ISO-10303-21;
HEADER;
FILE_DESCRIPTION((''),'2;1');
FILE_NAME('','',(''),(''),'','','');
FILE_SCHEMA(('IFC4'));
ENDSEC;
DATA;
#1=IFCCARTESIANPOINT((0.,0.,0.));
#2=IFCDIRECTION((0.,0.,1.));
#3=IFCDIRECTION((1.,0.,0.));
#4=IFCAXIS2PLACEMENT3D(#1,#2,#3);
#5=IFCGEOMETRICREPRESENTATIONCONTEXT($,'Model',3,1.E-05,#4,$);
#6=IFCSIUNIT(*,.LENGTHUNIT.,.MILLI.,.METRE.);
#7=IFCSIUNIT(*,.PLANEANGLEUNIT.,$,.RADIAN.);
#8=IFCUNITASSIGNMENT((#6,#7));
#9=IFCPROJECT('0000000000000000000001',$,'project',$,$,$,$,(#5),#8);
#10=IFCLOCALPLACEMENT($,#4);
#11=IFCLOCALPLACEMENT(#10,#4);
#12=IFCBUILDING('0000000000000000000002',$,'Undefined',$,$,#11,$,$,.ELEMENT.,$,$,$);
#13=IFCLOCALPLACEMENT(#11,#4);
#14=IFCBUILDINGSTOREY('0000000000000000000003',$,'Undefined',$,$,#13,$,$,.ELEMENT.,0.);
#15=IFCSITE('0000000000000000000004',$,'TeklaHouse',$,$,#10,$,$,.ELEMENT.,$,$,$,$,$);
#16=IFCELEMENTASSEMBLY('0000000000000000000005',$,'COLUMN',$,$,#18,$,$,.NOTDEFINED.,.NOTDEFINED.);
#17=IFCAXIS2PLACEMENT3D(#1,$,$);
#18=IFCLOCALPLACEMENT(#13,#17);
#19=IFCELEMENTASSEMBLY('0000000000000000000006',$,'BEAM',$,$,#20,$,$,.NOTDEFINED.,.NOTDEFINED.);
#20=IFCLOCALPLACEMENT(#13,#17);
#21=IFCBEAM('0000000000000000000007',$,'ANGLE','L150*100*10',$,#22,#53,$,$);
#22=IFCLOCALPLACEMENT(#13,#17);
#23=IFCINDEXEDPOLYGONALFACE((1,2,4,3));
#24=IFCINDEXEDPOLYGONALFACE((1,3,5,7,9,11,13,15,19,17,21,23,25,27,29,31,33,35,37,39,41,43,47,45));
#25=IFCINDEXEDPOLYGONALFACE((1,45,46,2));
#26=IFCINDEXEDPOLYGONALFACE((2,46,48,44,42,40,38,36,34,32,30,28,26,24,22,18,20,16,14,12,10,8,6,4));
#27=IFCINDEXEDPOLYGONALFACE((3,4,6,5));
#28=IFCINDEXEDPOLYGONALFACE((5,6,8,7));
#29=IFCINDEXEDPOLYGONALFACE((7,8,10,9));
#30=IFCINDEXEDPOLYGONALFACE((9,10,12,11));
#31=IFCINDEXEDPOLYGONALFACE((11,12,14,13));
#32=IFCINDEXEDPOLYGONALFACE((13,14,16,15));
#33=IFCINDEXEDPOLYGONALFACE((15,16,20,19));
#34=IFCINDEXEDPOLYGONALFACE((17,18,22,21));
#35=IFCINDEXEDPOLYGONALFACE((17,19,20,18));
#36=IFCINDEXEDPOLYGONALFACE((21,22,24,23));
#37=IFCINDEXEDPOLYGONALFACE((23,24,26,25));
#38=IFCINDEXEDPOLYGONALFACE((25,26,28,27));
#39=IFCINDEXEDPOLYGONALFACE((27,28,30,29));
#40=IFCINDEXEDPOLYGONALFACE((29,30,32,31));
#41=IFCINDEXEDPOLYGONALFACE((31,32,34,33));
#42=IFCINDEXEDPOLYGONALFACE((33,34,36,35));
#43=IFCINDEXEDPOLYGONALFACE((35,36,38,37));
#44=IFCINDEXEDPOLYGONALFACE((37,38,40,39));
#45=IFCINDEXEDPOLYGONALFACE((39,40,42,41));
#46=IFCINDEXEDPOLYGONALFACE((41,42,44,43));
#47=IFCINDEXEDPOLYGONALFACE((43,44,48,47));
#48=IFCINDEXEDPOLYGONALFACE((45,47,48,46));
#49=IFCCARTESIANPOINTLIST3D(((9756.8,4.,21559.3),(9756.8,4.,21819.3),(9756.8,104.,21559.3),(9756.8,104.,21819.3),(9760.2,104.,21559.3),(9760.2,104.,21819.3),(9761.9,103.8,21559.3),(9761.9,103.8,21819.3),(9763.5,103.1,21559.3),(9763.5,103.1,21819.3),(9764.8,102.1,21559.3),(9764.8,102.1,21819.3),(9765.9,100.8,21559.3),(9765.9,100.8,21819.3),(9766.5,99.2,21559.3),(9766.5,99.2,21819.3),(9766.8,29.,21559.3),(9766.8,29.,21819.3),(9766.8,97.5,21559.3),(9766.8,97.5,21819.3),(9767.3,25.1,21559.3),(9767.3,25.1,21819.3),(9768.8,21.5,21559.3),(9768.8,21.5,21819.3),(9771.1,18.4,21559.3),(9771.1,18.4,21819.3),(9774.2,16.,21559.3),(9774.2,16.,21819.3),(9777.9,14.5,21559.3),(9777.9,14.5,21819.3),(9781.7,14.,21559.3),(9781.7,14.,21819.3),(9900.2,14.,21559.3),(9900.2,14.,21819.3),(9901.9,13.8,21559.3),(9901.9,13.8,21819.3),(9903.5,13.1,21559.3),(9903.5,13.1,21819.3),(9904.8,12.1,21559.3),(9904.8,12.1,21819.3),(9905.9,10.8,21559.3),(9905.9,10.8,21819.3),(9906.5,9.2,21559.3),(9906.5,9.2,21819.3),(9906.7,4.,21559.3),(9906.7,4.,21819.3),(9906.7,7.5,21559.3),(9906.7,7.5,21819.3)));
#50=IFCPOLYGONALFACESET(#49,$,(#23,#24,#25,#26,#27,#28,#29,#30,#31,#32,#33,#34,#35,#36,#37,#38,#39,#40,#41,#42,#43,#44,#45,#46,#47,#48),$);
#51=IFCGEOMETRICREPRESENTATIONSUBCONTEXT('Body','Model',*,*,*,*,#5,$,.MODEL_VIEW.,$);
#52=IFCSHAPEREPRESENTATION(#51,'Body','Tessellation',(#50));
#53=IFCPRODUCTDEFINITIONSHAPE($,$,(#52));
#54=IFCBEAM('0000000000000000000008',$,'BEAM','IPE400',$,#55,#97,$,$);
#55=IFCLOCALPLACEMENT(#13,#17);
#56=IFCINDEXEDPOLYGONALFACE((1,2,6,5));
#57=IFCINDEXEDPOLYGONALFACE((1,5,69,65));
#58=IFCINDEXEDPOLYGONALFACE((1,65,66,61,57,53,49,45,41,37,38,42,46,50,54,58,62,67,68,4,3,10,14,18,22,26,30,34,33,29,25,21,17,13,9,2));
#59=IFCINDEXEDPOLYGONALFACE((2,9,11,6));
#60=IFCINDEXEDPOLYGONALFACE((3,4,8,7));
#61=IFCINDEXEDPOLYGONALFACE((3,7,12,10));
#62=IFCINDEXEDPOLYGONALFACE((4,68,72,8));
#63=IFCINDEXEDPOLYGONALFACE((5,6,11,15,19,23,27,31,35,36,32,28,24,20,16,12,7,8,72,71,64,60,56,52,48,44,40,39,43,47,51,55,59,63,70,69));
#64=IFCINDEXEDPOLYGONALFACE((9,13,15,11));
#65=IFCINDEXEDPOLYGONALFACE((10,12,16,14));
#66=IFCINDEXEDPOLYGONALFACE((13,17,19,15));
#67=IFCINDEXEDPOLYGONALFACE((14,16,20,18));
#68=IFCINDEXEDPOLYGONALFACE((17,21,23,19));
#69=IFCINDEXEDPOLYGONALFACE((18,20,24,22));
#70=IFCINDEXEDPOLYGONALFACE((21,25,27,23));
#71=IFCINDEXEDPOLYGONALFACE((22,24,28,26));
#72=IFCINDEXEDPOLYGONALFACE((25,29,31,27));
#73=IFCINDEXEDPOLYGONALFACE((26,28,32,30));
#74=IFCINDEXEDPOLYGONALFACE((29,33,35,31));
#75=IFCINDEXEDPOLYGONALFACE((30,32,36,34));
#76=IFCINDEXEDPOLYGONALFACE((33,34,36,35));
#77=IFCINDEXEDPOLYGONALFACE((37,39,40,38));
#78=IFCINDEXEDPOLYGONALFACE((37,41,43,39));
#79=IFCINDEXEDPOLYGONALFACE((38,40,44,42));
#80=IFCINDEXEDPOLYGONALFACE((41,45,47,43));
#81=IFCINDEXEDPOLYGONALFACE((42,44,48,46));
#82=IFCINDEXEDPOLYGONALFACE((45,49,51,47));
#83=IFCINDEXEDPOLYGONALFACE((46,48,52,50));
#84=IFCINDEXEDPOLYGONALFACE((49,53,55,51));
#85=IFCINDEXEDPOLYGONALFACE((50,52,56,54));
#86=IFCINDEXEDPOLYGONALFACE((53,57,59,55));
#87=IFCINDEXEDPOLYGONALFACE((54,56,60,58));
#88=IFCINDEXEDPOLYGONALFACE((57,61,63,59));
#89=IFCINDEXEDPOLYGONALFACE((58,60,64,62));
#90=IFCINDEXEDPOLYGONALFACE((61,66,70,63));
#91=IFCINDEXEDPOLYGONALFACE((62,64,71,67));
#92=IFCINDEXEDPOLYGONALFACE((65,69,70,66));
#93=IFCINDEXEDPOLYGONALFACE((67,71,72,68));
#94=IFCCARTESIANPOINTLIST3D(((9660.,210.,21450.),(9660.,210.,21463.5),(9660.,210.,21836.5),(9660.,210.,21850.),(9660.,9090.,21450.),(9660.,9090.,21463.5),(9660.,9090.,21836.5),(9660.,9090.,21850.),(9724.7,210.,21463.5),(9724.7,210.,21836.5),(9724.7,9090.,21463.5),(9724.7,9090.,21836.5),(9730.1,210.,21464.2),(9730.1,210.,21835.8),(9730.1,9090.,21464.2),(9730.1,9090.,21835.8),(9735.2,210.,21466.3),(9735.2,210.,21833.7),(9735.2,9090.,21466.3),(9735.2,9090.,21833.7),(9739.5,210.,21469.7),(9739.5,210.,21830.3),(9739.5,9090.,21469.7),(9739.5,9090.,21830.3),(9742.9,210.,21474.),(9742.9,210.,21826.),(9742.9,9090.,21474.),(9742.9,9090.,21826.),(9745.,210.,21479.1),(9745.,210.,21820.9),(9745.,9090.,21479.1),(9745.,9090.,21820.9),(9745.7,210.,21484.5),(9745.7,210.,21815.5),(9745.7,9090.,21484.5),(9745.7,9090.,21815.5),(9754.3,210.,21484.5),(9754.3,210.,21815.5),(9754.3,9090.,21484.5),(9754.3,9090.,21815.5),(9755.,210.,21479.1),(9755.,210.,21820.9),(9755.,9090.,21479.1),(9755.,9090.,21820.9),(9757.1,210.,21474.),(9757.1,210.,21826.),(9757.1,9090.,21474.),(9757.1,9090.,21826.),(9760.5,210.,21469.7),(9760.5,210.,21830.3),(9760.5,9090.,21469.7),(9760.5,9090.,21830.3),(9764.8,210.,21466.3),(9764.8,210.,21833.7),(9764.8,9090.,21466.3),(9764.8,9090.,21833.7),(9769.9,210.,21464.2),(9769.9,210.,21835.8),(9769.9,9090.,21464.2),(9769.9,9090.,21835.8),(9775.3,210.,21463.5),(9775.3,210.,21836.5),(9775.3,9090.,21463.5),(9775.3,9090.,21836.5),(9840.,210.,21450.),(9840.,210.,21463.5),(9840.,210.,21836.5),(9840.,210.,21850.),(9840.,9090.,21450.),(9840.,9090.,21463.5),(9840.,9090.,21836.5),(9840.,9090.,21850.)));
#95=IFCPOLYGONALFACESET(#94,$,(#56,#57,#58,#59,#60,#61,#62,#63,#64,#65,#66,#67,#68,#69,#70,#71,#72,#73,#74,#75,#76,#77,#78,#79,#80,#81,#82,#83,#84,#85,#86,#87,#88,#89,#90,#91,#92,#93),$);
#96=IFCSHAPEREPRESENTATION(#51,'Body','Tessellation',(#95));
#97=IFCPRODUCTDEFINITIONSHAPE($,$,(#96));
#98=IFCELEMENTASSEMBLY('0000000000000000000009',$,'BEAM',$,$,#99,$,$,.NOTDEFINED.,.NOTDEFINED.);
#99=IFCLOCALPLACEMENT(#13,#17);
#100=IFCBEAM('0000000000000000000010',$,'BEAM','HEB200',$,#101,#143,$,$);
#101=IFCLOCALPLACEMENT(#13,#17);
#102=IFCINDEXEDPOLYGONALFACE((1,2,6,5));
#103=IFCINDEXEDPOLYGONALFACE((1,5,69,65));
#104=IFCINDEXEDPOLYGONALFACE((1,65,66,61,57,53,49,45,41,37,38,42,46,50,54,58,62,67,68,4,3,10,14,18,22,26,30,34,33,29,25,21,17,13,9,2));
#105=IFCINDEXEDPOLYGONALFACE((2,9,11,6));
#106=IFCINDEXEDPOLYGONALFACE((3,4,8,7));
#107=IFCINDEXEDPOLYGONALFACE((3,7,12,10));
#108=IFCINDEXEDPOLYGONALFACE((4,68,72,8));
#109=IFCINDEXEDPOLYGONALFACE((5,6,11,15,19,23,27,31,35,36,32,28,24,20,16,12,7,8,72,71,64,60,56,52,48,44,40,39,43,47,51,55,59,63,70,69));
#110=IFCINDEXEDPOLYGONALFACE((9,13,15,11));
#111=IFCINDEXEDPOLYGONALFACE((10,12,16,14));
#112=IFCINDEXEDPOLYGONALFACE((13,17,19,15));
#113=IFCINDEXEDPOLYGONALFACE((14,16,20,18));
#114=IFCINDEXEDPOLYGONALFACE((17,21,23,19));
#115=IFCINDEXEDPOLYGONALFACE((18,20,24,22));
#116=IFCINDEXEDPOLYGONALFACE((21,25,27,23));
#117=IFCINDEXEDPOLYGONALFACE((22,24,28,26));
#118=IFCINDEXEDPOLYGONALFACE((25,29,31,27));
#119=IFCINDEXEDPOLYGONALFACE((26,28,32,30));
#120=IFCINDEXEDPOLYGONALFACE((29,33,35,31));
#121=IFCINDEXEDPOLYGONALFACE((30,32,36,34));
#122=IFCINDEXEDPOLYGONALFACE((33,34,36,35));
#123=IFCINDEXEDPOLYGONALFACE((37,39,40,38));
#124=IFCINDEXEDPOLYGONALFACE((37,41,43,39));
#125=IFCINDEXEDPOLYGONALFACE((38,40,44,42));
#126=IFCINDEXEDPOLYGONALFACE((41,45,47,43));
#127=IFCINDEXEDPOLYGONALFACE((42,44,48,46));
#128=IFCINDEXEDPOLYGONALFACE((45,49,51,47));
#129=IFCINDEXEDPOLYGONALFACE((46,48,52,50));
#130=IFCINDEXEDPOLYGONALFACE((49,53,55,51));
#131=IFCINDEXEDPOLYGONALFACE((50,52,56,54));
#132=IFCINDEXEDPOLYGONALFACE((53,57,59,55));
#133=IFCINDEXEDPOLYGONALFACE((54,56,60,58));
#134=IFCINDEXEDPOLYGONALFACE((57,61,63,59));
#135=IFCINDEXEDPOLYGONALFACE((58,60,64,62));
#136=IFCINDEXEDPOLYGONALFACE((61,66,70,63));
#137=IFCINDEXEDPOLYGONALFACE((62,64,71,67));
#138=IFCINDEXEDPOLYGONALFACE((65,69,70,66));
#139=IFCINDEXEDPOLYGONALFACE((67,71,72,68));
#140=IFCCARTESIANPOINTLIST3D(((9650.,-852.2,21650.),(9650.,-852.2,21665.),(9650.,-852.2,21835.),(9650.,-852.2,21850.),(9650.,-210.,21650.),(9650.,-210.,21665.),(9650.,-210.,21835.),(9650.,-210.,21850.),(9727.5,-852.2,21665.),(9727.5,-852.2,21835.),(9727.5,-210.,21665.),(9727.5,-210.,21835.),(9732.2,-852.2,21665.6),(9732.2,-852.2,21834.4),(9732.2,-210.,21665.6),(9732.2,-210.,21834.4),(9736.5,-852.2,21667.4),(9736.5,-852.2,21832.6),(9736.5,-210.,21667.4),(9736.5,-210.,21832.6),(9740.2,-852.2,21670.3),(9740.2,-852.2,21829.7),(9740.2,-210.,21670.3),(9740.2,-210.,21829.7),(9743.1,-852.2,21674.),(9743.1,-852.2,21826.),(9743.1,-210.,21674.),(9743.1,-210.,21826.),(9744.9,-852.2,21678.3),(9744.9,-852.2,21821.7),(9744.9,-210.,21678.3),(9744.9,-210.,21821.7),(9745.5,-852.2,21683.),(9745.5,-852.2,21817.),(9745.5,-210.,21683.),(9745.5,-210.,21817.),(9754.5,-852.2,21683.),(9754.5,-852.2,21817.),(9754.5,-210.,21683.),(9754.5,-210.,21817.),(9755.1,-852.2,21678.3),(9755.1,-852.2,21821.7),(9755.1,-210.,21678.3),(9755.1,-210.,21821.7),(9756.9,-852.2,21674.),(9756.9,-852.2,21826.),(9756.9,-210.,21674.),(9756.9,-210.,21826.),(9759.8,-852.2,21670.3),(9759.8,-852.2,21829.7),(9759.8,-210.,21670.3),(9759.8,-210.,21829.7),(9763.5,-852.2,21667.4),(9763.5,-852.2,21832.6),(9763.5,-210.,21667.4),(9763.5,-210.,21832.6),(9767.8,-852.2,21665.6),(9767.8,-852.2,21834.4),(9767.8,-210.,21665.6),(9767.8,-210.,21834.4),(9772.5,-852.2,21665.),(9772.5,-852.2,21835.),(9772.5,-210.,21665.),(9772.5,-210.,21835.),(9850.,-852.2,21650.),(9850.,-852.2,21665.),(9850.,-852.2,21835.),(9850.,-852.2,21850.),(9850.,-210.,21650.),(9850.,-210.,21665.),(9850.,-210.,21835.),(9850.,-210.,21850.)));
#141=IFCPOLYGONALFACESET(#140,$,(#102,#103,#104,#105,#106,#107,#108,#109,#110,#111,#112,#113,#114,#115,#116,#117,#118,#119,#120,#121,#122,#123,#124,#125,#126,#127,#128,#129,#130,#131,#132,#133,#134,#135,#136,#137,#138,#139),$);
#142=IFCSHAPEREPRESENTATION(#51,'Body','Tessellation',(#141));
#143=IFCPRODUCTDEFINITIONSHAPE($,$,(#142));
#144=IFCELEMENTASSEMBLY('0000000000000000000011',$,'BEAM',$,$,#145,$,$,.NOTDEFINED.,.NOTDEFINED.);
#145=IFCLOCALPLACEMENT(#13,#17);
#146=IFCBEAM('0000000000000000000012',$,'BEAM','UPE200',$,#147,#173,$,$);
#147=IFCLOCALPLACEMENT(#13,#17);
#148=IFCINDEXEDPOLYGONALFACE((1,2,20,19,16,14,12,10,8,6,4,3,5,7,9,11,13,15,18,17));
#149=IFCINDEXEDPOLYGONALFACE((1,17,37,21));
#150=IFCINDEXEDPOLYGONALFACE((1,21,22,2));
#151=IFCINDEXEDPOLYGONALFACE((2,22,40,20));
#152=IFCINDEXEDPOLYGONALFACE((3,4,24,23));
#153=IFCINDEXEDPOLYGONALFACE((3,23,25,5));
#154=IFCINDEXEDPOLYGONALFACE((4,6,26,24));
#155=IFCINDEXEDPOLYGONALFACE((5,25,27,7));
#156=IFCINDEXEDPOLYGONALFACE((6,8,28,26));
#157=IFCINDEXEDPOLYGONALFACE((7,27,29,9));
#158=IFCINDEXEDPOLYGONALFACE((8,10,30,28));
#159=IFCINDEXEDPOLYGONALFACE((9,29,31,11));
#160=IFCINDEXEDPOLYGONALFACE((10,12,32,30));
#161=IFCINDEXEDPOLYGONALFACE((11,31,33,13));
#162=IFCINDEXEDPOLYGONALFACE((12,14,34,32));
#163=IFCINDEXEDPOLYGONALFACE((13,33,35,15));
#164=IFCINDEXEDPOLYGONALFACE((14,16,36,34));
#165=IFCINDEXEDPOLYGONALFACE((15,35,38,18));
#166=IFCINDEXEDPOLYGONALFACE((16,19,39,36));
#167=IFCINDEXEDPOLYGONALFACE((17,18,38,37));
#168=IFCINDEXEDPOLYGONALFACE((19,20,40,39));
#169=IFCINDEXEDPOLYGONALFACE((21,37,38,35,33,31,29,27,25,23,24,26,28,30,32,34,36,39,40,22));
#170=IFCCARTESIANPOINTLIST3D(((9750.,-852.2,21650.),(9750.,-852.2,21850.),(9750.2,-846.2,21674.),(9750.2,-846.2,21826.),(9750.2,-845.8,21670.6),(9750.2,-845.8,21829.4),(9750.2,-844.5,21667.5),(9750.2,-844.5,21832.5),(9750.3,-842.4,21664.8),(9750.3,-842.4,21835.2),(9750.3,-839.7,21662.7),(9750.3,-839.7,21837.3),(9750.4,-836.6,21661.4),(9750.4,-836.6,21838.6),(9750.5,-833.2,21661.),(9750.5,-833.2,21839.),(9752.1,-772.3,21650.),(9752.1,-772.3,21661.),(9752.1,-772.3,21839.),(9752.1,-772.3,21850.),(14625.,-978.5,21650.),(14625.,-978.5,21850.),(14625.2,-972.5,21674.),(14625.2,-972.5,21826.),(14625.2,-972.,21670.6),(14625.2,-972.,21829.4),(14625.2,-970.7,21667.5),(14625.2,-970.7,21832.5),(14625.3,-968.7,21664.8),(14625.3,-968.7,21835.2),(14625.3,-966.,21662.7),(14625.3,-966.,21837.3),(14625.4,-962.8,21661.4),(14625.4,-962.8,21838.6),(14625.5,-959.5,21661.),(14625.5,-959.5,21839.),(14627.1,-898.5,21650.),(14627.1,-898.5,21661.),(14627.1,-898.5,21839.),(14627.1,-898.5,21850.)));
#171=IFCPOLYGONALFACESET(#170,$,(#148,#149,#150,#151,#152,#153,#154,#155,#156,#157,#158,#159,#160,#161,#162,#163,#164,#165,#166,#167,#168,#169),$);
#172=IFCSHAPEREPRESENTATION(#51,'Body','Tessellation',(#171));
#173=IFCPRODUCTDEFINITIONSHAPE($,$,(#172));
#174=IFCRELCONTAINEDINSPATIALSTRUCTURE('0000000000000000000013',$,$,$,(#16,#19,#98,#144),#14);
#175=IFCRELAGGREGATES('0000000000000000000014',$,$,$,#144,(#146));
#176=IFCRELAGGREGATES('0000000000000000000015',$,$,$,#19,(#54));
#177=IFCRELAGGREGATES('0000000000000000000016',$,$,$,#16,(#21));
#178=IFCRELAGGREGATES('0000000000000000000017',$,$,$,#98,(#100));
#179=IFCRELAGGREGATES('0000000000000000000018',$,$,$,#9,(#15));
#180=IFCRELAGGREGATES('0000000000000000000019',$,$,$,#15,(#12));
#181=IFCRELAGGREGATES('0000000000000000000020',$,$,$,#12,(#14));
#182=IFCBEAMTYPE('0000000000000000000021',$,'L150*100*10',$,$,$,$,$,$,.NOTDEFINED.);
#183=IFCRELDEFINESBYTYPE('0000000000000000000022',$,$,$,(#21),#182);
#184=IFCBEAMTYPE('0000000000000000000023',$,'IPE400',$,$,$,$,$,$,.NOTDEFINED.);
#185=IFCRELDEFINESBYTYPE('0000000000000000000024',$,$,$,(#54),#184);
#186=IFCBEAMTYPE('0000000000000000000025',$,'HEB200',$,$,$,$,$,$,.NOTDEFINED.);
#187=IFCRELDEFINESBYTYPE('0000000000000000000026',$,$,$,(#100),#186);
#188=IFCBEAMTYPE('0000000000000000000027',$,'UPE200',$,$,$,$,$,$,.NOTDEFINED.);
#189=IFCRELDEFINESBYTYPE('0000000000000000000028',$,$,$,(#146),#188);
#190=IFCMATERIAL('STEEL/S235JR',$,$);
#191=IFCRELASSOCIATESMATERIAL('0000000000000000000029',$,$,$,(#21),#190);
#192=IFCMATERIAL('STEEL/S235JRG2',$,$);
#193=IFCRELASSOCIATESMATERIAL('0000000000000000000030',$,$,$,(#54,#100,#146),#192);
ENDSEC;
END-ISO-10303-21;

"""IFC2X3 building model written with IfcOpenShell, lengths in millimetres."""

from ifc_helpers import new_model, si_unit, frame, origin_with_axes, origin_2d_with_axis, place, context, subcontext, project, spatial, rectangle, i_section, l_section, u_section, extrude, boolean, clip, halfspace, material, type_object, element, aggregate, save


model = new_model("IFC2X3")

# Units and contexts
model_context = context("Model", 3, precision=1e-05, world=origin_with_axes())
body_context = subcontext(model_context, "Body", "Model", "MODEL_VIEW")
ifc_project = project(units=[si_unit("LENGTHUNIT", "METRE", prefix="MILLI"), si_unit("PLANEANGLEUNIT", "RADIAN")], contexts=[model_context])

# Site, building, storey
site_placement = place(None, origin_with_axes())
site = spatial("IfcSite", under=ifc_project, at=site_placement, Name="TeklaHouse", CompositionType="ELEMENT")
building_placement = place(site_placement, origin_with_axes())
building = spatial("IfcBuilding", under=site, at=building_placement, Name="Undefined", CompositionType="ELEMENT")
storey_placement = place(building_placement, origin_with_axes())
storey = spatial("IfcBuildingStorey", under=building, at=storey_placement, Name="Undefined", CompositionType="ELEMENT", Elevation=0.0)

# Shared definitions
ifc_material_1 = material(Name="STEEL/S235JR")

# Element assemblies
assembly_1_placement = place(storey_placement, origin_with_axes())
assembly_1 = element("IfcElementAssembly", 1, at=assembly_1_placement, inside=storey, Name="COLUMN", AssemblyPlace="NOTDEFINED", PredefinedType="NOTDEFINED")
ifc_material_2 = material(Name="STEEL/S235JRG2")
assembly_2_placement = place(storey_placement, origin_with_axes())
assembly_2 = element("IfcElementAssembly", 2, at=assembly_2_placement, inside=storey, Name="BEAM", AssemblyPlace="NOTDEFINED", PredefinedType="NOTDEFINED")

# Beams
beam_type_1 = type_object("IfcBeamType", Name="L150*100*10", PredefinedType="NOTDEFINED")
beam_1_placement = place(assembly_1_placement, frame((9831.8, 54.0, 21559.3), z_axis=(1.0, 0.0, 0.0), x_axis=(0.0, 0.0, 1.0)))
beam_1 = element("IfcBeam", 3, at=beam_1_placement, type_object=beam_type_1, material=ifc_material_1, Name="ANGLE", Description="L150*100*10", context=body_context, shape_type="SweptSolid", body=[
    extrude(l_section(Depth=150.0, Width=100.0, Thickness=10.0, FilletRadius=15.0, EdgeRadius=6.5, at=origin_2d_with_axis()), frame((260.0, 0.0, 0.0), z_axis=(-1.0, 0.0, 0.0), x_axis=(0.0, -1.0, 0.0)), (0.0, 0.0, 1.0), 260.0),
])
beam_type_2 = type_object("IfcBeamType", Name="IPE400", PredefinedType="NOTDEFINED")
beam_2_placement = place(assembly_2_placement, frame((9750.0, 0.0, 21650.0), z_axis=(0.0, 0.0, 1.0), x_axis=(0.0, 1.0, 0.0)))
beam_2 = element("IfcBeam", 4, at=beam_2_placement, type_object=beam_type_2, material=ifc_material_2, Name="BEAM", Description="IPE400", context=body_context, shape_type="Clipping", body=[
    clip(clip(extrude(i_section(OverallWidth=180.0, OverallDepth=400.0, WebThickness=8.6, FlangeThickness=13.5, FilletRadius=21.0, at=origin_2d_with_axis()), frame((9300.0, 0.0, 0.0), z_axis=(-1.0, 0.0, 0.0), x_axis=(0.0, -1.0, 0.0)), (0.0, 0.0, 1.0), 9300.0), halfspace(frame((9090.0, 0.0, -200.0), z_axis=(-1.0, 0.0, 0.0), x_axis=(0.0, 1.0, 0.0)), True)), halfspace(frame((210.0, 0.0, -200.0), z_axis=(1.0, 0.0, 0.0), x_axis=(0.0, -1.0, 0.0)), True)),
])

# Element assemblies, beams
assembly_3_placement = place(storey_placement, origin_with_axes())
assembly_3 = element("IfcElementAssembly", 5, at=assembly_3_placement, inside=storey, Name="BEAM", AssemblyPlace="NOTDEFINED", PredefinedType="NOTDEFINED")
beam_type_3 = type_object("IfcBeamType", Name="HEB200", PredefinedType="NOTDEFINED")
beam_3_placement = place(assembly_3_placement, frame((9750.0, 0.0, 21750.0), z_axis=(0.0, 0.0, 1.0), x_axis=(0.0, -1.0, 0.0)))
beam_3 = element("IfcBeam", 6, at=beam_3_placement, type_object=beam_type_3, material=ifc_material_2, Name="BEAM", Description="HEB200", context=body_context, shape_type="CSG", body=[
    boolean("DIFFERENCE", boolean("DIFFERENCE", extrude(i_section(OverallWidth=200.0, OverallDepth=200.0, WebThickness=9.0, FlangeThickness=15.0, FilletRadius=18.0, at=origin_2d_with_axis()), frame((852.2, 0.0, 0.0), z_axis=(-1.0, 0.0, 0.0), x_axis=(0.0, -1.0, 0.0)), (0.0, 0.0, 1.0), 852.2), extrude(rectangle(XDim=170.0, YDim=170.0, at=origin_2d_with_axis()), frame((285.0, 90.1, 60.0), z_axis=(0.0, 0.0, -1.0), x_axis=(1.0, 0.0, 0.0)), (0.0, 0.0, 1.0), 112.0)), halfspace(frame((210.0, 0.0, 200.0), z_axis=(-1.0, 0.0, 0.0), x_axis=(0.0, -1.0, 0.0)), False)),
])
assembly_4_placement = place(storey_placement, origin_with_axes())
assembly_4 = element("IfcElementAssembly", 7, at=assembly_4_placement, inside=storey, Name="BEAM", AssemblyPlace="NOTDEFINED", PredefinedType="NOTDEFINED")
beam_type_4 = type_object("IfcBeamType", Name="UPE200", PredefinedType="NOTDEFINED")
beam_4_placement = place(assembly_4_placement, frame((9751.0, -812.2, 21750.0), z_axis=(0.0, 0.0, -1.0), x_axis=(0.999665, -0.025886, 0.0)))
beam_4 = element("IfcBeam", 8, at=beam_4_placement, type_object=beam_type_4, material=ifc_material_2, Name="BEAM", Description="UPE200", context=body_context, shape_type="SweptSolid", body=[
    extrude(u_section(Depth=200.0, FlangeWidth=80.0, WebThickness=6.0, FlangeThickness=11.0, FilletRadius=13.0, at=origin_2d_with_axis()), frame((4876.6, 0.0, 0.0), z_axis=(-1.0, 0.0, 0.0), x_axis=(0.0, -1.0, 0.0)), (0.0, 0.0, 1.0), 4876.6),
])
aggregate(assembly_4, [beam_4])

aggregate(assembly_2, [beam_2])
aggregate(assembly_1, [beam_1])

aggregate(assembly_3, [beam_3])

save(model, "model.ifc")
